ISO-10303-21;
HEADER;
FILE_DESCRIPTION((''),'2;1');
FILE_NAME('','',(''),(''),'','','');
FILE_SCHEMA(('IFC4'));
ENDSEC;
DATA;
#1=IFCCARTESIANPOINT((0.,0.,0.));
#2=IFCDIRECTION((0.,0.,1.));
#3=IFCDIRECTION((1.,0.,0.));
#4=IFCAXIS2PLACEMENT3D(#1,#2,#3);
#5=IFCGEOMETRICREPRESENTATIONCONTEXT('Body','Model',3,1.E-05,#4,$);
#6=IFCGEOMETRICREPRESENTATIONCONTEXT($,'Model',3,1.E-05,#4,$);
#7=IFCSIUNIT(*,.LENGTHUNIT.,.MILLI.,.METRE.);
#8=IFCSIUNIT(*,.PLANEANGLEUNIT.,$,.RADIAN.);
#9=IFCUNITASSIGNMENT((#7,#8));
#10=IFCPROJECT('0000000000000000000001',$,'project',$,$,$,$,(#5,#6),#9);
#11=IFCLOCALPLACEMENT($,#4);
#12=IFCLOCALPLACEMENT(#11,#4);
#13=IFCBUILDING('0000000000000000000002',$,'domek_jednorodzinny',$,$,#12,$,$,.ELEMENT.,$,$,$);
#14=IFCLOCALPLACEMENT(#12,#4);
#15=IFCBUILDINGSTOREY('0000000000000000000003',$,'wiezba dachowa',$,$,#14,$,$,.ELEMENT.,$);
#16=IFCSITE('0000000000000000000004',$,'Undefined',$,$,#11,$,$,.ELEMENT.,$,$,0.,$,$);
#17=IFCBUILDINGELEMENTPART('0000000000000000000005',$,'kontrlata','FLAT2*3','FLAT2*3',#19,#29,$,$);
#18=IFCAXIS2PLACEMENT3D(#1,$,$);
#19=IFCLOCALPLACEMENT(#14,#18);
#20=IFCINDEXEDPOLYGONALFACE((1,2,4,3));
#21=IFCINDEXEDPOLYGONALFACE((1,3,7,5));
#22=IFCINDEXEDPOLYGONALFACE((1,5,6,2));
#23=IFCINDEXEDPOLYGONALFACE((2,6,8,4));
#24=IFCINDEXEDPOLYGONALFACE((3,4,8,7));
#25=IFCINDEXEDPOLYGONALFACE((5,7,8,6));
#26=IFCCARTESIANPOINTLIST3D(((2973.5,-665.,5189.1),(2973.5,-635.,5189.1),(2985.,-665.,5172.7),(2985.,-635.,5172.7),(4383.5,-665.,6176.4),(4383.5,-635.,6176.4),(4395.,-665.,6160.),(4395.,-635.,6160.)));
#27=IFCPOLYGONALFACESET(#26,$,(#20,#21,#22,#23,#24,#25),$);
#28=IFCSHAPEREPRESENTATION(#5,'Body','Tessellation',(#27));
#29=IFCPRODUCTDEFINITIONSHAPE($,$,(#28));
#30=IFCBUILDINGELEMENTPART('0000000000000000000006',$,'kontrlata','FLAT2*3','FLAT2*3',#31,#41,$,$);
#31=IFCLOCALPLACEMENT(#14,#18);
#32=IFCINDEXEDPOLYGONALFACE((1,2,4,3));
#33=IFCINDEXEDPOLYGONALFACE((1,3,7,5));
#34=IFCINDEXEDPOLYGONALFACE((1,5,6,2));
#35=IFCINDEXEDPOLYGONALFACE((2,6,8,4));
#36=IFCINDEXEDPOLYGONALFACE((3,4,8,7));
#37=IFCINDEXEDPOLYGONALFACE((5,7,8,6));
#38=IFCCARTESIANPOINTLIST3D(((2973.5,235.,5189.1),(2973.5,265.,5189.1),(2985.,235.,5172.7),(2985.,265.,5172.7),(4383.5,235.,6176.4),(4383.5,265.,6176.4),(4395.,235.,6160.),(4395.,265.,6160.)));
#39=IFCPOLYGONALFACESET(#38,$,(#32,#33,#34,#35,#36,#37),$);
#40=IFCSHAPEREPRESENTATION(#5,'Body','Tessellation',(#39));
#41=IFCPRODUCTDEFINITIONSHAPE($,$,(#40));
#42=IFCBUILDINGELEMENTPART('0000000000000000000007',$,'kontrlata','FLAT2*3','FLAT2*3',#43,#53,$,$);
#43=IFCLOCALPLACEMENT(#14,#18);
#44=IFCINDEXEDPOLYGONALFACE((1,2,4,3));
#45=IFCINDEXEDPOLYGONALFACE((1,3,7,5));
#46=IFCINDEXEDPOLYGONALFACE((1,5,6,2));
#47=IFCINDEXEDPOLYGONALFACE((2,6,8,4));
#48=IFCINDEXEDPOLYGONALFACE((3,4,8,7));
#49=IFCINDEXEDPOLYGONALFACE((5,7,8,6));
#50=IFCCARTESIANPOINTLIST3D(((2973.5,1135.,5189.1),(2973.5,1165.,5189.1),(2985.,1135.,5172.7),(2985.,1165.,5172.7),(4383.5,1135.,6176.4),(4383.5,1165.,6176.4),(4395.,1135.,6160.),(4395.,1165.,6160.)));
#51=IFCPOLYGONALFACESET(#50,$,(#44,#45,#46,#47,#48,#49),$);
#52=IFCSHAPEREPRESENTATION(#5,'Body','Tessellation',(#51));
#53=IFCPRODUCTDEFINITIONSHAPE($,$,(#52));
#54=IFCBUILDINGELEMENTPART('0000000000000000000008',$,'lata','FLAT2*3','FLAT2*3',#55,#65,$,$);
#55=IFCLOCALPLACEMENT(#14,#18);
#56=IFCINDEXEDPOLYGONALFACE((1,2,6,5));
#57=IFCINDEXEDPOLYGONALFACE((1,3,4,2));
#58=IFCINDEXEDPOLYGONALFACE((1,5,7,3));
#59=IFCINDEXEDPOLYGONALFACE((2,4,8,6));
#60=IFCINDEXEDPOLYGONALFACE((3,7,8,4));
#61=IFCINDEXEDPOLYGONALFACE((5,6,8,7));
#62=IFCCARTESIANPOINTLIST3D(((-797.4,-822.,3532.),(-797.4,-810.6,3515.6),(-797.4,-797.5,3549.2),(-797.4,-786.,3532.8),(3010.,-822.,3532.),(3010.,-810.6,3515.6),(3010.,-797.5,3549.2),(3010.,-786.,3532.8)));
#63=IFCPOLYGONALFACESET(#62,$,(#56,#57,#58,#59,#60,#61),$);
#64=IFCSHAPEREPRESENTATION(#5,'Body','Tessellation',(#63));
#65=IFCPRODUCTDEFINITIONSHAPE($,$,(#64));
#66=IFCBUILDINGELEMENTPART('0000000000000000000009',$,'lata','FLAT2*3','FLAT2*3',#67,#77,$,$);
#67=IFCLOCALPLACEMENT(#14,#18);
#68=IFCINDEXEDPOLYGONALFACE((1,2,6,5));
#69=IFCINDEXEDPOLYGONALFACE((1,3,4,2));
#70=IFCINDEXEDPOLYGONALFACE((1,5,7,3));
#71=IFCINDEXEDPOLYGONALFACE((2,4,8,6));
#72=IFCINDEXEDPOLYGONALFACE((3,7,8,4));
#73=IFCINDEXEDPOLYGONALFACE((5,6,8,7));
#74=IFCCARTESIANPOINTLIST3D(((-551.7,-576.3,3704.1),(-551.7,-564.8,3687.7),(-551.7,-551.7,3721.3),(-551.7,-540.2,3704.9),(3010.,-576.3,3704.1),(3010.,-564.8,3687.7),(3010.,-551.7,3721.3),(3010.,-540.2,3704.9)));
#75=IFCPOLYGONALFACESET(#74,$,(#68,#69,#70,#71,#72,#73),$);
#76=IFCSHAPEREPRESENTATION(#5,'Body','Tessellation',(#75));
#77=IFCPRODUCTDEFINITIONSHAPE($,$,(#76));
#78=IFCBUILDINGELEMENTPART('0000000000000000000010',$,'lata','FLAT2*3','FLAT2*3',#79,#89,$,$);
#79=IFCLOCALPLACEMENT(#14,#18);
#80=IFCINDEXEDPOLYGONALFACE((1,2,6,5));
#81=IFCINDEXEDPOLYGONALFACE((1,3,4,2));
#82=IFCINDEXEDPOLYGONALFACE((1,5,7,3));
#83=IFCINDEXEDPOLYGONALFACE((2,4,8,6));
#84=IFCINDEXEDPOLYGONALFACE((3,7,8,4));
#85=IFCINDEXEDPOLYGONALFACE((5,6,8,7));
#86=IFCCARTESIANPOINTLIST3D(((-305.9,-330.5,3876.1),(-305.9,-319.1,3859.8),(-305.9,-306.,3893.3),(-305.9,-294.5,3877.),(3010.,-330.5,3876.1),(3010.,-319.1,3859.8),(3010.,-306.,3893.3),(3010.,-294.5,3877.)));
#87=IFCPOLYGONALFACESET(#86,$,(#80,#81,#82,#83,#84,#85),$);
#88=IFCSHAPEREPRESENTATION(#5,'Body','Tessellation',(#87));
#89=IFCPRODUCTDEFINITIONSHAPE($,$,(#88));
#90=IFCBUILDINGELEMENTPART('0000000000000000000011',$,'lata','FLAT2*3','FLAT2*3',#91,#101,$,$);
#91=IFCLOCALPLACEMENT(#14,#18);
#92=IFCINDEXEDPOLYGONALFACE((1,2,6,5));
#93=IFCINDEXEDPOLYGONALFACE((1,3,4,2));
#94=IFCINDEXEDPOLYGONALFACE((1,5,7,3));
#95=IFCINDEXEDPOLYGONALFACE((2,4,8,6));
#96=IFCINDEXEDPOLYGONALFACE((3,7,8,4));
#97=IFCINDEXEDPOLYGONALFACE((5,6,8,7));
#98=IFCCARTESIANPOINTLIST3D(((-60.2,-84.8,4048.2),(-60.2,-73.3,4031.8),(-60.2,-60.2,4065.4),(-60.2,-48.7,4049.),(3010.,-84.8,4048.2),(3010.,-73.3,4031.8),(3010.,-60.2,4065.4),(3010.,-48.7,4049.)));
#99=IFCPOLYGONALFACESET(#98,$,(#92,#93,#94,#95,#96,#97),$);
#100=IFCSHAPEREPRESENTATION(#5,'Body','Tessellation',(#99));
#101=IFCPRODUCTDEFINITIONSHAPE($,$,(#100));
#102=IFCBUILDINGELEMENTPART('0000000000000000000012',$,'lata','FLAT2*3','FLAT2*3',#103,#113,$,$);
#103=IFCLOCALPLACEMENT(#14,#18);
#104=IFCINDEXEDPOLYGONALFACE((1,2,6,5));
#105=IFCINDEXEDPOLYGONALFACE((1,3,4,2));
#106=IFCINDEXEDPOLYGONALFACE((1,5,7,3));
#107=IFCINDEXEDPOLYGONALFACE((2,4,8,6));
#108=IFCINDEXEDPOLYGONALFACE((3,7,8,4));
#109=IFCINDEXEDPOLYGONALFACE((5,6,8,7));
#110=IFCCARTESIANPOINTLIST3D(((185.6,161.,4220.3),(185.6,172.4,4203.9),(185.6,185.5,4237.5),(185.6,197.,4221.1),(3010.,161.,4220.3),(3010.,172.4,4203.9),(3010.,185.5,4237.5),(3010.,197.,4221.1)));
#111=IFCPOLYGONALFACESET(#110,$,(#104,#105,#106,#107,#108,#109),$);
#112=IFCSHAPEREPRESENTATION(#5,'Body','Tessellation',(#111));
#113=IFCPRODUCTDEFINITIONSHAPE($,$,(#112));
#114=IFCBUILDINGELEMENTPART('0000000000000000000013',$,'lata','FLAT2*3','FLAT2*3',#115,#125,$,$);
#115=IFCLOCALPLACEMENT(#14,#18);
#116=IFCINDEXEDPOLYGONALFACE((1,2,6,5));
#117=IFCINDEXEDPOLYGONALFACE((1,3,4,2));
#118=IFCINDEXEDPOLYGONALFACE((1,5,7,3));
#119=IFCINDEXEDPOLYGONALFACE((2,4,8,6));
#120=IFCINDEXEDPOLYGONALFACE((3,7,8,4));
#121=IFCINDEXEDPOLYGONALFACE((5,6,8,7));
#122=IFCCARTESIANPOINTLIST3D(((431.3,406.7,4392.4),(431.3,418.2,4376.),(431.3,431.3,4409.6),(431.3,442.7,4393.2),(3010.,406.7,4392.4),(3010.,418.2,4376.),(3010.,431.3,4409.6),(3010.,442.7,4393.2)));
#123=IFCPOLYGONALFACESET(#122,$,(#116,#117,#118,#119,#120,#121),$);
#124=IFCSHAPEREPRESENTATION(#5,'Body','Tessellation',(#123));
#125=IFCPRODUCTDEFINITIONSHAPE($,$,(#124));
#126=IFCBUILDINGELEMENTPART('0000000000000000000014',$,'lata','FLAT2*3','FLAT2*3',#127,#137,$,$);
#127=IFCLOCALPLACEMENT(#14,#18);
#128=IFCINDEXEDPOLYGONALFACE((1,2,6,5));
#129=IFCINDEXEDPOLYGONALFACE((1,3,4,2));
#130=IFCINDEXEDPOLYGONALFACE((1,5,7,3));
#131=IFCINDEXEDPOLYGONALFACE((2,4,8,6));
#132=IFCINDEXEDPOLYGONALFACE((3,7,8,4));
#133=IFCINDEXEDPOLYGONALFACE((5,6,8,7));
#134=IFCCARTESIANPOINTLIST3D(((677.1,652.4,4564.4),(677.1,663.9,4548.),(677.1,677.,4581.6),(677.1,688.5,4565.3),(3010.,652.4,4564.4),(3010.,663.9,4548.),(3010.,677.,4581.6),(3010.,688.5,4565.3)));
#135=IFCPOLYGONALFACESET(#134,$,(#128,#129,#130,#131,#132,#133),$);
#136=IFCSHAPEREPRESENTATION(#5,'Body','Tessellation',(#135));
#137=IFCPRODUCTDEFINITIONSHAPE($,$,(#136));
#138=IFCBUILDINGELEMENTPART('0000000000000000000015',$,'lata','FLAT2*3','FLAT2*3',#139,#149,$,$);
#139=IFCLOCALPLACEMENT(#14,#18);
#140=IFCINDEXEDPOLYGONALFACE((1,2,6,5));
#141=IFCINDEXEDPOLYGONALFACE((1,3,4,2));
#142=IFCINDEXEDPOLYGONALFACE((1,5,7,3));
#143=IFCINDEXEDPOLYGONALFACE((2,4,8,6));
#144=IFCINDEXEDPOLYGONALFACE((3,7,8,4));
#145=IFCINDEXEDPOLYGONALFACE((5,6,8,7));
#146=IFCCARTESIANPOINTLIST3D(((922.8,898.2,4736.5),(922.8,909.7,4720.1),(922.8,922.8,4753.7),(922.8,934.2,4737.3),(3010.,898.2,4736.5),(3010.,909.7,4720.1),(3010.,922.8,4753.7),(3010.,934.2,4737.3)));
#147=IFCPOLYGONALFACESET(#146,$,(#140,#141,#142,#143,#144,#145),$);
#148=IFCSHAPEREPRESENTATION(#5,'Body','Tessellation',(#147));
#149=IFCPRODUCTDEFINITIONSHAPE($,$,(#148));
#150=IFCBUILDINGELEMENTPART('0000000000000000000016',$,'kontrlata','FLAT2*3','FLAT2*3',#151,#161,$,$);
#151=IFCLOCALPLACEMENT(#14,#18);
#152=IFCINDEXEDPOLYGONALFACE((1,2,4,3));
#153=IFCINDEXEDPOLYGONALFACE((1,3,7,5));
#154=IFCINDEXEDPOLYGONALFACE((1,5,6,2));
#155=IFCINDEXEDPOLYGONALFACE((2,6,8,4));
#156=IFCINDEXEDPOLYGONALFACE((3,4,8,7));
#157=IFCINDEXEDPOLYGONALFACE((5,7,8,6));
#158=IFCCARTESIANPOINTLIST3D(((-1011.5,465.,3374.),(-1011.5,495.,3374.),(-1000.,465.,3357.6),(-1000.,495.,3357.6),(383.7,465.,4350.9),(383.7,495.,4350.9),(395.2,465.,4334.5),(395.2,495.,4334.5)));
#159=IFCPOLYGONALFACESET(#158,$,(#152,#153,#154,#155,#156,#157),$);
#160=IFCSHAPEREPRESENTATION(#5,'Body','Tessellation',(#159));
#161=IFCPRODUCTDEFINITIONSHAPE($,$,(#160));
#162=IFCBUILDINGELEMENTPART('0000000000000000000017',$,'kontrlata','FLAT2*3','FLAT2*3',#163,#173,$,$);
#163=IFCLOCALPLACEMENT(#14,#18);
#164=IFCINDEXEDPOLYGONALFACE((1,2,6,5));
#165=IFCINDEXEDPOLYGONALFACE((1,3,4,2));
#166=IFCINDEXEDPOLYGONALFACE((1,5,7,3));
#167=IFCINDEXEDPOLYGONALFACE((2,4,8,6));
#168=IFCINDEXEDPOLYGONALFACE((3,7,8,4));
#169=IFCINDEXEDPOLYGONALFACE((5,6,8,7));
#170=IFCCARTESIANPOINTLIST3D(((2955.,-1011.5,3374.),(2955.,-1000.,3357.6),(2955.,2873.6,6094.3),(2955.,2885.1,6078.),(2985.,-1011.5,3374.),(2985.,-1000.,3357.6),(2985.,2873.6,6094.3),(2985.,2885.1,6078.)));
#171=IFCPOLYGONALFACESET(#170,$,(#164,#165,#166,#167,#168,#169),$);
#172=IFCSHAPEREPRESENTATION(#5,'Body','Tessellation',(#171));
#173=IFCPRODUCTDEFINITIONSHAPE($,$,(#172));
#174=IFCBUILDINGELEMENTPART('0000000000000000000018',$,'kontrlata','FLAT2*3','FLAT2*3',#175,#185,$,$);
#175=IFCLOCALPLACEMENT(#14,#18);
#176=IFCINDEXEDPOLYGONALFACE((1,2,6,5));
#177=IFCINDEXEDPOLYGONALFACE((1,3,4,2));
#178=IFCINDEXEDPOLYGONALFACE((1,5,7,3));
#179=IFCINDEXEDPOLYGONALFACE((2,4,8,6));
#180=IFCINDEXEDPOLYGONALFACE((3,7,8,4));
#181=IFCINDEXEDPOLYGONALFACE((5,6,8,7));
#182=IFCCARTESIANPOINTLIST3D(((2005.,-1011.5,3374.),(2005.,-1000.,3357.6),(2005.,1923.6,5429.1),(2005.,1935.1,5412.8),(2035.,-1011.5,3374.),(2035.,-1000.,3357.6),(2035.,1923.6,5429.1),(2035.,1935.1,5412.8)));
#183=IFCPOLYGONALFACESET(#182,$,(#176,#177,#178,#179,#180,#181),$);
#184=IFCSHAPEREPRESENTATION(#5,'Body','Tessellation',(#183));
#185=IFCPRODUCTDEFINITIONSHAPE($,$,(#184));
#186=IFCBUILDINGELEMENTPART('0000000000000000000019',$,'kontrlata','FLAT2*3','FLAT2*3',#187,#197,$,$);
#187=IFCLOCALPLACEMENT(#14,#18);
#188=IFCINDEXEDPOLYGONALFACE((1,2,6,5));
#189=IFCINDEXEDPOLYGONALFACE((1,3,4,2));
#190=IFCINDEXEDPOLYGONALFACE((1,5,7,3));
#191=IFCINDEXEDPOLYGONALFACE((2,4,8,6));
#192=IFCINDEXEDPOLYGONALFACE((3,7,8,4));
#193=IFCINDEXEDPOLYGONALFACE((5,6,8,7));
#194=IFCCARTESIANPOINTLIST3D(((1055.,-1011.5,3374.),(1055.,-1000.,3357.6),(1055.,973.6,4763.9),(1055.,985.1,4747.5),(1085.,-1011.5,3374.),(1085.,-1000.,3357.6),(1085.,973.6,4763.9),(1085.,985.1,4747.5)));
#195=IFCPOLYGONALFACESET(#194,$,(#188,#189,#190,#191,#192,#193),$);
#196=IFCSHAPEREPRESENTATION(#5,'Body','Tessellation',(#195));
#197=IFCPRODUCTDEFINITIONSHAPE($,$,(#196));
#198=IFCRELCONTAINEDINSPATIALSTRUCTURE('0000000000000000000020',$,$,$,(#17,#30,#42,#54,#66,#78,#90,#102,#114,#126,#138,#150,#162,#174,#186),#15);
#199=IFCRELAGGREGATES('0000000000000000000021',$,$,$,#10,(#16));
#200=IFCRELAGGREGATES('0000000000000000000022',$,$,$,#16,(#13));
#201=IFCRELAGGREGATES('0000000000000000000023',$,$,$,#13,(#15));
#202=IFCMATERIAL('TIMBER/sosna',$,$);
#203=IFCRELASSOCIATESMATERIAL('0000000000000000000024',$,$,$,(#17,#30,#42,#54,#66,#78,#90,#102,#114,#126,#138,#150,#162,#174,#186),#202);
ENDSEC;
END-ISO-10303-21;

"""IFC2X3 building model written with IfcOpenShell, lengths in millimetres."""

from ifc_helpers import new_model, si_unit, frame, origin_with_axes, origin_2d_with_axis, place, context, project, spatial, rectangle, extrude, material, element, save


model = new_model("IFC2X3")

# Units and contexts
model_context_1 = context("Model", 3, precision=1e-05, world=origin_with_axes(), identifier="Body")
model_context_2 = context("Model", 3, precision=1e-05, world=origin_with_axes())
ifc_project = project(units=[si_unit("LENGTHUNIT", "METRE", prefix="MILLI"), si_unit("PLANEANGLEUNIT", "RADIAN")], contexts=[model_context_1, model_context_2])

# Site, building, storey
site_placement = place(None, origin_with_axes())
site = spatial("IfcSite", under=ifc_project, at=site_placement, Name="Undefined", CompositionType="ELEMENT", RefElevation=0.0)
building_placement = place(site_placement, origin_with_axes())
building = spatial("IfcBuilding", under=site, at=building_placement, Name="domek_jednorodzinny", CompositionType="ELEMENT")
storey_placement = place(building_placement, origin_with_axes())
storey = spatial("IfcBuildingStorey", under=building, at=storey_placement, Name="wiezba dachowa", CompositionType="ELEMENT")

# Building element parts
ifc_material = material(Name="TIMBER/sosna")
building_element_part_1_placement = place(storey_placement, frame((2979.3, -650.0, 5180.9), z_axis=(0.0, 1.0, 0.0), x_axis=(0.819152, 0.0, 0.573576)))
element("IfcBuildingElementPart", 1, at=building_element_part_1_placement, inside=storey, material=ifc_material, Name="kontrlata", Description="FLAT2*3", ObjectType="FLAT2*3", context=model_context_1, shape_type="SweptSolid", body=[
    extrude(rectangle(XDim=20.0, YDim=30.0, at=origin_2d_with_axis()), frame((1721.3, 0.0, 0.0), z_axis=(-1.0, 0.0, 0.0), x_axis=(0.0, -1.0, 0.0)), (0.0, 0.0, 1.0), 1721.3),
])
for number, where, z_axis, x_axis, name in (
    (2, (2979.3, 250.0, 5180.9), (0.0, 1.0, 0.0), (0.819152, 0.0, 0.573576), "kontrlata"),
    (3, (2979.3, 1150.0, 5180.9), (0.0, 1.0, 0.0), (0.819152, 0.0, 0.573576), "kontrlata"),
):
    element("IfcBuildingElementPart", number, at=place(storey_placement, frame(where, z_axis=z_axis, x_axis=x_axis)), inside=storey, material=ifc_material, Name=name, Description="FLAT2*3", ObjectType="FLAT2*3", context=model_context_1, shape_type="SweptSolid", body=[
        extrude(rectangle(XDim=20.0, YDim=30.0, at=origin_2d_with_axis()), frame((1721.3, 0.0, 0.0), z_axis=(-1.0, 0.0, 0.0), x_axis=(0.0, -1.0, 0.0)), (0.0, 0.0, 1.0), 1721.3),
    ])
building_element_part_2_placement = place(storey_placement, frame((3010.0, -804.0, 3532.4), z_axis=(0.0, 0.819154, 0.573574), x_axis=(-1.0, 0.0, 0.0)))
element("IfcBuildingElementPart", 4, at=building_element_part_2_placement, inside=storey, material=ifc_material, Name="lata", Description="FLAT2*3", ObjectType="FLAT2*3", context=model_context_1, shape_type="SweptSolid", body=[
    extrude(rectangle(XDim=20.0, YDim=30.0, at=origin_2d_with_axis()), frame((3807.4, 0.0, 0.0), z_axis=(-1.0, 0.0, 0.0), x_axis=(0.0, -1.0, 0.0)), (0.0, 0.0, 1.0), 3807.4),
])
building_element_part_3_placement = place(storey_placement, frame((3010.0, -558.3, 3704.5), z_axis=(0.0, 0.819154, 0.573574), x_axis=(-1.0, 0.0, 0.0)))
element("IfcBuildingElementPart", 5, at=building_element_part_3_placement, inside=storey, material=ifc_material, Name="lata", Description="FLAT2*3", ObjectType="FLAT2*3", context=model_context_1, shape_type="SweptSolid", body=[
    extrude(rectangle(XDim=20.0, YDim=30.0, at=origin_2d_with_axis()), frame((3561.7, 0.0, 0.0), z_axis=(-1.0, 0.0, 0.0), x_axis=(0.0, -1.0, 0.0)), (0.0, 0.0, 1.0), 3561.7),
])
building_element_part_4_placement = place(storey_placement, frame((3010.0, -312.5, 3876.5), z_axis=(0.0, 0.819154, 0.573574), x_axis=(-1.0, 0.0, 0.0)))
element("IfcBuildingElementPart", 6, at=building_element_part_4_placement, inside=storey, material=ifc_material, Name="lata", Description="FLAT2*3", ObjectType="FLAT2*3", context=model_context_1, shape_type="SweptSolid", body=[
    extrude(rectangle(XDim=20.0, YDim=30.0, at=origin_2d_with_axis()), frame((3316.0, 0.0, 0.0), z_axis=(-1.0, 0.0, 0.0), x_axis=(0.0, -1.0, 0.0)), (0.0, 0.0, 1.0), 3316.0),
])
building_element_part_5_placement = place(storey_placement, frame((3010.0, -66.8, 4048.6), z_axis=(0.0, 0.819154, 0.573574), x_axis=(-1.0, 0.0, 0.0)))
element("IfcBuildingElementPart", 7, at=building_element_part_5_placement, inside=storey, material=ifc_material, Name="lata", Description="FLAT2*3", ObjectType="FLAT2*3", context=model_context_1, shape_type="SweptSolid", body=[
    extrude(rectangle(XDim=20.0, YDim=30.0, at=origin_2d_with_axis()), frame((3070.2, 0.0, 0.0), z_axis=(-1.0, 0.0, 0.0), x_axis=(0.0, -1.0, 0.0)), (0.0, 0.0, 1.0), 3070.2),
])
building_element_part_6_placement = place(storey_placement, frame((3010.0, 179.0, 4220.7), z_axis=(0.0, 0.819154, 0.573574), x_axis=(-1.0, 0.0, 0.0)))
element("IfcBuildingElementPart", 8, at=building_element_part_6_placement, inside=storey, material=ifc_material, Name="lata", Description="FLAT2*3", ObjectType="FLAT2*3", context=model_context_1, shape_type="SweptSolid", body=[
    extrude(rectangle(XDim=20.0, YDim=30.0, at=origin_2d_with_axis()), frame((2824.5, 0.0, 0.0), z_axis=(-1.0, 0.0, 0.0), x_axis=(0.0, -1.0, 0.0)), (0.0, 0.0, 1.0), 2824.5),
])
building_element_part_7_placement = place(storey_placement, frame((3010.0, 424.7, 4392.8), z_axis=(0.0, 0.819154, 0.573574), x_axis=(-1.0, 0.0, 0.0)))
element("IfcBuildingElementPart", 9, at=building_element_part_7_placement, inside=storey, material=ifc_material, Name="lata", Description="FLAT2*3", ObjectType="FLAT2*3", context=model_context_1, shape_type="SweptSolid", body=[
    extrude(rectangle(XDim=20.0, YDim=30.0, at=origin_2d_with_axis()), frame((2578.7, 0.0, 0.0), z_axis=(-1.0, 0.0, 0.0), x_axis=(0.0, -1.0, 0.0)), (0.0, 0.0, 1.0), 2578.7),
])
building_element_part_8_placement = place(storey_placement, frame((3010.0, 670.5, 4564.8), z_axis=(0.0, 0.819154, 0.573574), x_axis=(-1.0, 0.0, 0.0)))
element("IfcBuildingElementPart", 10, at=building_element_part_8_placement, inside=storey, material=ifc_material, Name="lata", Description="FLAT2*3", ObjectType="FLAT2*3", context=model_context_1, shape_type="SweptSolid", body=[
    extrude(rectangle(XDim=20.0, YDim=30.0, at=origin_2d_with_axis()), frame((2333.0, 0.0, 0.0), z_axis=(-1.0, 0.0, 0.0), x_axis=(0.0, -1.0, 0.0)), (0.0, 0.0, 1.0), 2333.0),
])
building_element_part_9_placement = place(storey_placement, frame((3010.0, 916.2, 4736.9), z_axis=(0.0, 0.819154, 0.573574), x_axis=(-1.0, 0.0, 0.0)))
element("IfcBuildingElementPart", 11, at=building_element_part_9_placement, inside=storey, material=ifc_material, Name="lata", Description="FLAT2*3", ObjectType="FLAT2*3", context=model_context_1, shape_type="SweptSolid", body=[
    extrude(rectangle(XDim=20.0, YDim=30.0, at=origin_2d_with_axis()), frame((2087.2, 0.0, 0.0), z_axis=(-1.0, 0.0, 0.0), x_axis=(0.0, -1.0, 0.0)), (0.0, 0.0, 1.0), 2087.2),
])
building_element_part_10_placement = place(storey_placement, frame((-1005.7, 480.0, 3365.8), z_axis=(0.0, -1.0, 0.0), x_axis=(0.819152, 0.0, 0.573576)))
element("IfcBuildingElementPart", 12, at=building_element_part_10_placement, inside=storey, material=ifc_material, Name="kontrlata", Description="FLAT2*3", ObjectType="FLAT2*3", context=model_context_1, shape_type="SweptSolid", body=[
    extrude(rectangle(XDim=20.0, YDim=30.0, at=origin_2d_with_axis()), frame((1703.2, 0.0, 0.0), z_axis=(-1.0, 0.0, 0.0), x_axis=(0.0, -1.0, 0.0)), (0.0, 0.0, 1.0), 1703.2),
])
building_element_part_11_placement = place(storey_placement, frame((2970.0, -1005.7, 3365.8), z_axis=(-1.0, 0.0, 0.0), x_axis=(0.0, 0.819154, 0.573574)))
element("IfcBuildingElementPart", 13, at=building_element_part_11_placement, inside=storey, material=ifc_material, Name="kontrlata", Description="FLAT2*3", ObjectType="FLAT2*3", context=model_context_1, shape_type="SweptSolid", body=[
    extrude(rectangle(XDim=20.0, YDim=30.0, at=origin_2d_with_axis()), frame((4742.8, 0.0, 0.0), z_axis=(-1.0, 0.0, 0.0), x_axis=(0.0, -1.0, 0.0)), (0.0, 0.0, 1.0), 4742.8),
])
building_element_part_12_placement = place(storey_placement, frame((2020.0, -1005.7, 3365.8), z_axis=(-1.0, 0.0, 0.0), x_axis=(0.0, 0.819154, 0.573574)))
element("IfcBuildingElementPart", 14, at=building_element_part_12_placement, inside=storey, material=ifc_material, Name="kontrlata", Description="FLAT2*3", ObjectType="FLAT2*3", context=model_context_1, shape_type="SweptSolid", body=[
    extrude(rectangle(XDim=20.0, YDim=30.0, at=origin_2d_with_axis()), frame((3583.1, 0.0, 0.0), z_axis=(-1.0, 0.0, 0.0), x_axis=(0.0, -1.0, 0.0)), (0.0, 0.0, 1.0), 3583.1),
])
building_element_part_13_placement = place(storey_placement, frame((1070.0, -1005.7, 3365.8), z_axis=(-1.0, 0.0, 0.0), x_axis=(0.0, 0.819154, 0.573574)))
element("IfcBuildingElementPart", 15, at=building_element_part_13_placement, inside=storey, material=ifc_material, Name="kontrlata", Description="FLAT2*3", ObjectType="FLAT2*3", context=model_context_1, shape_type="SweptSolid", body=[
    extrude(rectangle(XDim=20.0, YDim=30.0, at=origin_2d_with_axis()), frame((2423.3, 0.0, 0.0), z_axis=(-1.0, 0.0, 0.0), x_axis=(0.0, -1.0, 0.0)), (0.0, 0.0, 1.0), 2423.3),
])

save(model, "model.ifc")
